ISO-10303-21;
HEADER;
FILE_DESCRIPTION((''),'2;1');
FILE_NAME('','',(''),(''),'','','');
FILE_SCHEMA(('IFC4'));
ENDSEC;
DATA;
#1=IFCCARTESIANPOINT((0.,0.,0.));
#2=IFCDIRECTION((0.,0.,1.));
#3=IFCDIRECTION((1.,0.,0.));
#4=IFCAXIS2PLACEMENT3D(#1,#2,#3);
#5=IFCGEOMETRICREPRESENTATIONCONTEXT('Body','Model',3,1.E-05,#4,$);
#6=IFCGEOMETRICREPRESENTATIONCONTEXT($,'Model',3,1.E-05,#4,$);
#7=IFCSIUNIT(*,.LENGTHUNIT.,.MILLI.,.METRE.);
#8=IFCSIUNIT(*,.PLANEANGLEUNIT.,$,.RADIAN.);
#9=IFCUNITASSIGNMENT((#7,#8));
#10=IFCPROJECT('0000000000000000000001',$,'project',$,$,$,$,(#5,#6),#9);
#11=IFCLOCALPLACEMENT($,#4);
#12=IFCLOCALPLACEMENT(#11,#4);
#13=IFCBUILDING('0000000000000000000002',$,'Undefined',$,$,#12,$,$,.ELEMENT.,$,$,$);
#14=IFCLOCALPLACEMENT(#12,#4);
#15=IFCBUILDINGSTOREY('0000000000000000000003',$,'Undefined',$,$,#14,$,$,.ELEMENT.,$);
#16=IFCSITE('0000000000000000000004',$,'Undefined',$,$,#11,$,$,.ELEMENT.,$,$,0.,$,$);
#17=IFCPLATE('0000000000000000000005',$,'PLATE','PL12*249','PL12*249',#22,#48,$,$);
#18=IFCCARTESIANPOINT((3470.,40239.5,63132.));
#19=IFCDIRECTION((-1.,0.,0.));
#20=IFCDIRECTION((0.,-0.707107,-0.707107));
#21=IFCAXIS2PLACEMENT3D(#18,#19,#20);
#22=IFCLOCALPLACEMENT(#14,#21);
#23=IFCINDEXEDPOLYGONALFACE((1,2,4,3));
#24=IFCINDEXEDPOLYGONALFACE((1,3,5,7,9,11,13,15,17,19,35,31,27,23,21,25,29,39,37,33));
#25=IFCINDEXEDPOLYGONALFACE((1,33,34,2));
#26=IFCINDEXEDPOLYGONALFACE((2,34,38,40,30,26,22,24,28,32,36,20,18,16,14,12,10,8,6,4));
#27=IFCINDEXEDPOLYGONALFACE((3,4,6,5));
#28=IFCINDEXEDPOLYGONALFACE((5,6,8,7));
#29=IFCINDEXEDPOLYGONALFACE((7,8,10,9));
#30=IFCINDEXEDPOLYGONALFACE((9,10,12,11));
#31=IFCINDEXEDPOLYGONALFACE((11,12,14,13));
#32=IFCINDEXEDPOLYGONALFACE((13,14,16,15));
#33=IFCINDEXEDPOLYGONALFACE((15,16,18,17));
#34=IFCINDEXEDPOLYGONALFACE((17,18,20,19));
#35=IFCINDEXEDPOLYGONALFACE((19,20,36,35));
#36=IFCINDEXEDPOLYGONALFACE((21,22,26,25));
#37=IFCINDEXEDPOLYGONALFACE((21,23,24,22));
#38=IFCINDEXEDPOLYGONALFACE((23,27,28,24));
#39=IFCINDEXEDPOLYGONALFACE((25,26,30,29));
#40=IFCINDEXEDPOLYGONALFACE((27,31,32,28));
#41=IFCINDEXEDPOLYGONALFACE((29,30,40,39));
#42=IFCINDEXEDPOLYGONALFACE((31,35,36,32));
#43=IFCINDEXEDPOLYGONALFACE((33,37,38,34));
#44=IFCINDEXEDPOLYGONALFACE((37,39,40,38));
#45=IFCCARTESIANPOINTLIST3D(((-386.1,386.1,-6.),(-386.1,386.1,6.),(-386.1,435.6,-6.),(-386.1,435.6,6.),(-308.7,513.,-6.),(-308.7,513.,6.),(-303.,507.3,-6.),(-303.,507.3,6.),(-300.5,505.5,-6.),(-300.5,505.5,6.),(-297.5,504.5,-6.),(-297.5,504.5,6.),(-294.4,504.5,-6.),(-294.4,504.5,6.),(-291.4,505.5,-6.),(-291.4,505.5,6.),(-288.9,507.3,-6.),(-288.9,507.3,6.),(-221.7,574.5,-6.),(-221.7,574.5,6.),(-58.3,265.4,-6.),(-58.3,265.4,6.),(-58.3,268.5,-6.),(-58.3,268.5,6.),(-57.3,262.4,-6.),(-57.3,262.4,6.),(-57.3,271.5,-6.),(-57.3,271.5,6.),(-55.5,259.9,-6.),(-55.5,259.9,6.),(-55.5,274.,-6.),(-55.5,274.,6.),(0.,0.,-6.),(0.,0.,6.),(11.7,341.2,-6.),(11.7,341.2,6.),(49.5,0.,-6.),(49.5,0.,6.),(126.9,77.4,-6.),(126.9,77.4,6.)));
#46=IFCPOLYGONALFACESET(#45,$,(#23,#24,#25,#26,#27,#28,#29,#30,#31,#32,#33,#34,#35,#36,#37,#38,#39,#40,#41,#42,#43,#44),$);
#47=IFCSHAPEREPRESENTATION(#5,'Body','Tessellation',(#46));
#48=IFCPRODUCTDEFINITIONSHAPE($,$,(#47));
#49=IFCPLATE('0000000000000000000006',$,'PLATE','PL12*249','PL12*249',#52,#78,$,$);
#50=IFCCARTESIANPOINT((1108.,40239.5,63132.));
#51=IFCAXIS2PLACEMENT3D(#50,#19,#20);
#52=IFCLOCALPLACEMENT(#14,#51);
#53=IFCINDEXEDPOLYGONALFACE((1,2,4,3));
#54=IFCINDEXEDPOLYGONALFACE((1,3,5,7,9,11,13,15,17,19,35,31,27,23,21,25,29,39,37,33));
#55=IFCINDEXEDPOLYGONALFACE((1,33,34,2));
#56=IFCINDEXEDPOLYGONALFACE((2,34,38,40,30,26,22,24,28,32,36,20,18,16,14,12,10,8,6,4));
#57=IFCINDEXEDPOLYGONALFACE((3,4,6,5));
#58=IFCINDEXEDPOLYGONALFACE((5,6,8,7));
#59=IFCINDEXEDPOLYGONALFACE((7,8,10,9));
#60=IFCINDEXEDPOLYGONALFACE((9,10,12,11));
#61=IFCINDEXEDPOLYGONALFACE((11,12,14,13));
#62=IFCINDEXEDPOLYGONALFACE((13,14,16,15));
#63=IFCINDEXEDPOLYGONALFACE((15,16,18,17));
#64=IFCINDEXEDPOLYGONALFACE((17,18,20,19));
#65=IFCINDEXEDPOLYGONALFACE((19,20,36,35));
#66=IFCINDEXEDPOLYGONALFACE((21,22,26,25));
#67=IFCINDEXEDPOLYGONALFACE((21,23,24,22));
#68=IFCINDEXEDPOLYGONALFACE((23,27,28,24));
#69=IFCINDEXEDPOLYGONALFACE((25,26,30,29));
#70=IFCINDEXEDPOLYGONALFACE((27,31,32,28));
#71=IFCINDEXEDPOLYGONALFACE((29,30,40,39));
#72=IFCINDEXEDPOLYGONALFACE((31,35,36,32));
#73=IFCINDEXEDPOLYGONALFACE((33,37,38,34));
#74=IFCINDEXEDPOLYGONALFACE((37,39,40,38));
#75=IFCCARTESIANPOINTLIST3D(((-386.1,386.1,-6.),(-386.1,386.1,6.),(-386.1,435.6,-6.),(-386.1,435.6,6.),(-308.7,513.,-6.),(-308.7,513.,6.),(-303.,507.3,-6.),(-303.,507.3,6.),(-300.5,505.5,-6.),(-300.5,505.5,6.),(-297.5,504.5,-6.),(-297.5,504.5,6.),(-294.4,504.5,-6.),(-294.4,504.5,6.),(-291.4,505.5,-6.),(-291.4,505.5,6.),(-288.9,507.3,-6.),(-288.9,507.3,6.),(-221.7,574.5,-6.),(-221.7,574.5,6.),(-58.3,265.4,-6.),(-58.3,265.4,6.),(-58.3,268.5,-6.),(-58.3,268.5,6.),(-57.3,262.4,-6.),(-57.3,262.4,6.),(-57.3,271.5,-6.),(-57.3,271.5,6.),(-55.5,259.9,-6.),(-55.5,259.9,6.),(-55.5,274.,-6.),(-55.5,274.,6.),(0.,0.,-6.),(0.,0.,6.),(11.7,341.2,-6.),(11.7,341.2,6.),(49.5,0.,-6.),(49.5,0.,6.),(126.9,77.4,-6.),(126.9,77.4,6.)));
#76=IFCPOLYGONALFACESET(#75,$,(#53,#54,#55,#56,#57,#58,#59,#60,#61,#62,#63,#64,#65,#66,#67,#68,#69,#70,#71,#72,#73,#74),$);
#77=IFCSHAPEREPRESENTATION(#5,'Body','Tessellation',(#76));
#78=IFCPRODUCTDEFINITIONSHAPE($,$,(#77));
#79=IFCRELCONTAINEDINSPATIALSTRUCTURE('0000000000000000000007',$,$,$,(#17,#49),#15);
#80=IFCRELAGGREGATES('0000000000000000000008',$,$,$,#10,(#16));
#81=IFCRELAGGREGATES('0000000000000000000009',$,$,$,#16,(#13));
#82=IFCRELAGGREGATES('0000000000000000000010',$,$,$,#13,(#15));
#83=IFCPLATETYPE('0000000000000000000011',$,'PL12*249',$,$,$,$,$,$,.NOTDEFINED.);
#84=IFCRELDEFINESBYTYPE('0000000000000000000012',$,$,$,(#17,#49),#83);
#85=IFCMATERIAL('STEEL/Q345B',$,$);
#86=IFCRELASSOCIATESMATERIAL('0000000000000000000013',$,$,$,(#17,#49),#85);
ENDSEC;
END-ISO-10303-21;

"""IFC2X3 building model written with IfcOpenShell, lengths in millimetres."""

from ifc_helpers import new_model, si_unit, frame, origin_with_axes, place, context, project, spatial, polyline, outline, extrude, material, type_object, element, save


model = new_model("IFC2X3")

# Units and contexts
model_context_1 = context("Model", 3, precision=1e-05, world=origin_with_axes(), identifier="Body")
model_context_2 = context("Model", 3, precision=1e-05, world=origin_with_axes())
ifc_project = project(units=[si_unit("LENGTHUNIT", "METRE", prefix="MILLI"), si_unit("PLANEANGLEUNIT", "RADIAN")], contexts=[model_context_1, model_context_2])

# Site, building, storey
site_placement = place(None, origin_with_axes())
site = spatial("IfcSite", under=ifc_project, at=site_placement, Name="Undefined", CompositionType="ELEMENT", RefElevation=0.0)
building_placement = place(site_placement, origin_with_axes())
building = spatial("IfcBuilding", under=site, at=building_placement, Name="Undefined", CompositionType="ELEMENT")
storey_placement = place(building_placement, origin_with_axes())
storey = spatial("IfcBuildingStorey", under=building, at=storey_placement, Name="Undefined", CompositionType="ELEMENT")

# Shared definitions
ifc_material_1 = material(Name="STEEL/Q345B")

# Plates
plate_type_1 = type_object("IfcPlateType", Name="PL12*249", PredefinedType="NOTDEFINED")
for number, where, z_axis, x_axis, name in (
    (1, (3470.0, 40239.5, 63132.0), (-1.0, 0.0, 0.0), (0.0, -0.707107, -0.707107), "PLATE"),
    (2, (1108.0, 40239.5, 63132.0), (-1.0, 0.0, 0.0), (0.0, -0.707107, -0.707107), "PLATE"),
):
    element("IfcPlate", number, at=place(storey_placement, frame(where, z_axis=z_axis, x_axis=x_axis)), inside=storey, type_object=plate_type_1, material=ifc_material_1, Name=name, Description="PL12*249", ObjectType="PL12*249", context=model_context_1, shape_type="SweptSolid", body=[
        extrude(outline(polyline([(0.0, 0.0), (49.5, 0.0), (126.9, 77.4), (-55.5, 259.9), (-57.3, 262.4), (-58.3, 265.4), (-58.3, 268.5), (-57.3, 271.5), (-55.5, 274.0), (11.7, 341.2), (-221.7, 574.5), (-288.9, 507.3), (-291.4, 505.5), (-294.4, 504.5), (-297.5, 504.5), (-300.5, 505.5), (-303.0, 507.3), (-308.7, 513.0), (-386.1, 435.6), (-386.1, 386.1), (0.0, 0.0)])), frame((0.0, 0.0, -6.0), z_axis=(0.0, 0.0, 1.0), x_axis=(1.0, 0.0, 0.0)), (0.0, 0.0, 1.0), 12.0),
    ])

save(model, "model.ifc")
